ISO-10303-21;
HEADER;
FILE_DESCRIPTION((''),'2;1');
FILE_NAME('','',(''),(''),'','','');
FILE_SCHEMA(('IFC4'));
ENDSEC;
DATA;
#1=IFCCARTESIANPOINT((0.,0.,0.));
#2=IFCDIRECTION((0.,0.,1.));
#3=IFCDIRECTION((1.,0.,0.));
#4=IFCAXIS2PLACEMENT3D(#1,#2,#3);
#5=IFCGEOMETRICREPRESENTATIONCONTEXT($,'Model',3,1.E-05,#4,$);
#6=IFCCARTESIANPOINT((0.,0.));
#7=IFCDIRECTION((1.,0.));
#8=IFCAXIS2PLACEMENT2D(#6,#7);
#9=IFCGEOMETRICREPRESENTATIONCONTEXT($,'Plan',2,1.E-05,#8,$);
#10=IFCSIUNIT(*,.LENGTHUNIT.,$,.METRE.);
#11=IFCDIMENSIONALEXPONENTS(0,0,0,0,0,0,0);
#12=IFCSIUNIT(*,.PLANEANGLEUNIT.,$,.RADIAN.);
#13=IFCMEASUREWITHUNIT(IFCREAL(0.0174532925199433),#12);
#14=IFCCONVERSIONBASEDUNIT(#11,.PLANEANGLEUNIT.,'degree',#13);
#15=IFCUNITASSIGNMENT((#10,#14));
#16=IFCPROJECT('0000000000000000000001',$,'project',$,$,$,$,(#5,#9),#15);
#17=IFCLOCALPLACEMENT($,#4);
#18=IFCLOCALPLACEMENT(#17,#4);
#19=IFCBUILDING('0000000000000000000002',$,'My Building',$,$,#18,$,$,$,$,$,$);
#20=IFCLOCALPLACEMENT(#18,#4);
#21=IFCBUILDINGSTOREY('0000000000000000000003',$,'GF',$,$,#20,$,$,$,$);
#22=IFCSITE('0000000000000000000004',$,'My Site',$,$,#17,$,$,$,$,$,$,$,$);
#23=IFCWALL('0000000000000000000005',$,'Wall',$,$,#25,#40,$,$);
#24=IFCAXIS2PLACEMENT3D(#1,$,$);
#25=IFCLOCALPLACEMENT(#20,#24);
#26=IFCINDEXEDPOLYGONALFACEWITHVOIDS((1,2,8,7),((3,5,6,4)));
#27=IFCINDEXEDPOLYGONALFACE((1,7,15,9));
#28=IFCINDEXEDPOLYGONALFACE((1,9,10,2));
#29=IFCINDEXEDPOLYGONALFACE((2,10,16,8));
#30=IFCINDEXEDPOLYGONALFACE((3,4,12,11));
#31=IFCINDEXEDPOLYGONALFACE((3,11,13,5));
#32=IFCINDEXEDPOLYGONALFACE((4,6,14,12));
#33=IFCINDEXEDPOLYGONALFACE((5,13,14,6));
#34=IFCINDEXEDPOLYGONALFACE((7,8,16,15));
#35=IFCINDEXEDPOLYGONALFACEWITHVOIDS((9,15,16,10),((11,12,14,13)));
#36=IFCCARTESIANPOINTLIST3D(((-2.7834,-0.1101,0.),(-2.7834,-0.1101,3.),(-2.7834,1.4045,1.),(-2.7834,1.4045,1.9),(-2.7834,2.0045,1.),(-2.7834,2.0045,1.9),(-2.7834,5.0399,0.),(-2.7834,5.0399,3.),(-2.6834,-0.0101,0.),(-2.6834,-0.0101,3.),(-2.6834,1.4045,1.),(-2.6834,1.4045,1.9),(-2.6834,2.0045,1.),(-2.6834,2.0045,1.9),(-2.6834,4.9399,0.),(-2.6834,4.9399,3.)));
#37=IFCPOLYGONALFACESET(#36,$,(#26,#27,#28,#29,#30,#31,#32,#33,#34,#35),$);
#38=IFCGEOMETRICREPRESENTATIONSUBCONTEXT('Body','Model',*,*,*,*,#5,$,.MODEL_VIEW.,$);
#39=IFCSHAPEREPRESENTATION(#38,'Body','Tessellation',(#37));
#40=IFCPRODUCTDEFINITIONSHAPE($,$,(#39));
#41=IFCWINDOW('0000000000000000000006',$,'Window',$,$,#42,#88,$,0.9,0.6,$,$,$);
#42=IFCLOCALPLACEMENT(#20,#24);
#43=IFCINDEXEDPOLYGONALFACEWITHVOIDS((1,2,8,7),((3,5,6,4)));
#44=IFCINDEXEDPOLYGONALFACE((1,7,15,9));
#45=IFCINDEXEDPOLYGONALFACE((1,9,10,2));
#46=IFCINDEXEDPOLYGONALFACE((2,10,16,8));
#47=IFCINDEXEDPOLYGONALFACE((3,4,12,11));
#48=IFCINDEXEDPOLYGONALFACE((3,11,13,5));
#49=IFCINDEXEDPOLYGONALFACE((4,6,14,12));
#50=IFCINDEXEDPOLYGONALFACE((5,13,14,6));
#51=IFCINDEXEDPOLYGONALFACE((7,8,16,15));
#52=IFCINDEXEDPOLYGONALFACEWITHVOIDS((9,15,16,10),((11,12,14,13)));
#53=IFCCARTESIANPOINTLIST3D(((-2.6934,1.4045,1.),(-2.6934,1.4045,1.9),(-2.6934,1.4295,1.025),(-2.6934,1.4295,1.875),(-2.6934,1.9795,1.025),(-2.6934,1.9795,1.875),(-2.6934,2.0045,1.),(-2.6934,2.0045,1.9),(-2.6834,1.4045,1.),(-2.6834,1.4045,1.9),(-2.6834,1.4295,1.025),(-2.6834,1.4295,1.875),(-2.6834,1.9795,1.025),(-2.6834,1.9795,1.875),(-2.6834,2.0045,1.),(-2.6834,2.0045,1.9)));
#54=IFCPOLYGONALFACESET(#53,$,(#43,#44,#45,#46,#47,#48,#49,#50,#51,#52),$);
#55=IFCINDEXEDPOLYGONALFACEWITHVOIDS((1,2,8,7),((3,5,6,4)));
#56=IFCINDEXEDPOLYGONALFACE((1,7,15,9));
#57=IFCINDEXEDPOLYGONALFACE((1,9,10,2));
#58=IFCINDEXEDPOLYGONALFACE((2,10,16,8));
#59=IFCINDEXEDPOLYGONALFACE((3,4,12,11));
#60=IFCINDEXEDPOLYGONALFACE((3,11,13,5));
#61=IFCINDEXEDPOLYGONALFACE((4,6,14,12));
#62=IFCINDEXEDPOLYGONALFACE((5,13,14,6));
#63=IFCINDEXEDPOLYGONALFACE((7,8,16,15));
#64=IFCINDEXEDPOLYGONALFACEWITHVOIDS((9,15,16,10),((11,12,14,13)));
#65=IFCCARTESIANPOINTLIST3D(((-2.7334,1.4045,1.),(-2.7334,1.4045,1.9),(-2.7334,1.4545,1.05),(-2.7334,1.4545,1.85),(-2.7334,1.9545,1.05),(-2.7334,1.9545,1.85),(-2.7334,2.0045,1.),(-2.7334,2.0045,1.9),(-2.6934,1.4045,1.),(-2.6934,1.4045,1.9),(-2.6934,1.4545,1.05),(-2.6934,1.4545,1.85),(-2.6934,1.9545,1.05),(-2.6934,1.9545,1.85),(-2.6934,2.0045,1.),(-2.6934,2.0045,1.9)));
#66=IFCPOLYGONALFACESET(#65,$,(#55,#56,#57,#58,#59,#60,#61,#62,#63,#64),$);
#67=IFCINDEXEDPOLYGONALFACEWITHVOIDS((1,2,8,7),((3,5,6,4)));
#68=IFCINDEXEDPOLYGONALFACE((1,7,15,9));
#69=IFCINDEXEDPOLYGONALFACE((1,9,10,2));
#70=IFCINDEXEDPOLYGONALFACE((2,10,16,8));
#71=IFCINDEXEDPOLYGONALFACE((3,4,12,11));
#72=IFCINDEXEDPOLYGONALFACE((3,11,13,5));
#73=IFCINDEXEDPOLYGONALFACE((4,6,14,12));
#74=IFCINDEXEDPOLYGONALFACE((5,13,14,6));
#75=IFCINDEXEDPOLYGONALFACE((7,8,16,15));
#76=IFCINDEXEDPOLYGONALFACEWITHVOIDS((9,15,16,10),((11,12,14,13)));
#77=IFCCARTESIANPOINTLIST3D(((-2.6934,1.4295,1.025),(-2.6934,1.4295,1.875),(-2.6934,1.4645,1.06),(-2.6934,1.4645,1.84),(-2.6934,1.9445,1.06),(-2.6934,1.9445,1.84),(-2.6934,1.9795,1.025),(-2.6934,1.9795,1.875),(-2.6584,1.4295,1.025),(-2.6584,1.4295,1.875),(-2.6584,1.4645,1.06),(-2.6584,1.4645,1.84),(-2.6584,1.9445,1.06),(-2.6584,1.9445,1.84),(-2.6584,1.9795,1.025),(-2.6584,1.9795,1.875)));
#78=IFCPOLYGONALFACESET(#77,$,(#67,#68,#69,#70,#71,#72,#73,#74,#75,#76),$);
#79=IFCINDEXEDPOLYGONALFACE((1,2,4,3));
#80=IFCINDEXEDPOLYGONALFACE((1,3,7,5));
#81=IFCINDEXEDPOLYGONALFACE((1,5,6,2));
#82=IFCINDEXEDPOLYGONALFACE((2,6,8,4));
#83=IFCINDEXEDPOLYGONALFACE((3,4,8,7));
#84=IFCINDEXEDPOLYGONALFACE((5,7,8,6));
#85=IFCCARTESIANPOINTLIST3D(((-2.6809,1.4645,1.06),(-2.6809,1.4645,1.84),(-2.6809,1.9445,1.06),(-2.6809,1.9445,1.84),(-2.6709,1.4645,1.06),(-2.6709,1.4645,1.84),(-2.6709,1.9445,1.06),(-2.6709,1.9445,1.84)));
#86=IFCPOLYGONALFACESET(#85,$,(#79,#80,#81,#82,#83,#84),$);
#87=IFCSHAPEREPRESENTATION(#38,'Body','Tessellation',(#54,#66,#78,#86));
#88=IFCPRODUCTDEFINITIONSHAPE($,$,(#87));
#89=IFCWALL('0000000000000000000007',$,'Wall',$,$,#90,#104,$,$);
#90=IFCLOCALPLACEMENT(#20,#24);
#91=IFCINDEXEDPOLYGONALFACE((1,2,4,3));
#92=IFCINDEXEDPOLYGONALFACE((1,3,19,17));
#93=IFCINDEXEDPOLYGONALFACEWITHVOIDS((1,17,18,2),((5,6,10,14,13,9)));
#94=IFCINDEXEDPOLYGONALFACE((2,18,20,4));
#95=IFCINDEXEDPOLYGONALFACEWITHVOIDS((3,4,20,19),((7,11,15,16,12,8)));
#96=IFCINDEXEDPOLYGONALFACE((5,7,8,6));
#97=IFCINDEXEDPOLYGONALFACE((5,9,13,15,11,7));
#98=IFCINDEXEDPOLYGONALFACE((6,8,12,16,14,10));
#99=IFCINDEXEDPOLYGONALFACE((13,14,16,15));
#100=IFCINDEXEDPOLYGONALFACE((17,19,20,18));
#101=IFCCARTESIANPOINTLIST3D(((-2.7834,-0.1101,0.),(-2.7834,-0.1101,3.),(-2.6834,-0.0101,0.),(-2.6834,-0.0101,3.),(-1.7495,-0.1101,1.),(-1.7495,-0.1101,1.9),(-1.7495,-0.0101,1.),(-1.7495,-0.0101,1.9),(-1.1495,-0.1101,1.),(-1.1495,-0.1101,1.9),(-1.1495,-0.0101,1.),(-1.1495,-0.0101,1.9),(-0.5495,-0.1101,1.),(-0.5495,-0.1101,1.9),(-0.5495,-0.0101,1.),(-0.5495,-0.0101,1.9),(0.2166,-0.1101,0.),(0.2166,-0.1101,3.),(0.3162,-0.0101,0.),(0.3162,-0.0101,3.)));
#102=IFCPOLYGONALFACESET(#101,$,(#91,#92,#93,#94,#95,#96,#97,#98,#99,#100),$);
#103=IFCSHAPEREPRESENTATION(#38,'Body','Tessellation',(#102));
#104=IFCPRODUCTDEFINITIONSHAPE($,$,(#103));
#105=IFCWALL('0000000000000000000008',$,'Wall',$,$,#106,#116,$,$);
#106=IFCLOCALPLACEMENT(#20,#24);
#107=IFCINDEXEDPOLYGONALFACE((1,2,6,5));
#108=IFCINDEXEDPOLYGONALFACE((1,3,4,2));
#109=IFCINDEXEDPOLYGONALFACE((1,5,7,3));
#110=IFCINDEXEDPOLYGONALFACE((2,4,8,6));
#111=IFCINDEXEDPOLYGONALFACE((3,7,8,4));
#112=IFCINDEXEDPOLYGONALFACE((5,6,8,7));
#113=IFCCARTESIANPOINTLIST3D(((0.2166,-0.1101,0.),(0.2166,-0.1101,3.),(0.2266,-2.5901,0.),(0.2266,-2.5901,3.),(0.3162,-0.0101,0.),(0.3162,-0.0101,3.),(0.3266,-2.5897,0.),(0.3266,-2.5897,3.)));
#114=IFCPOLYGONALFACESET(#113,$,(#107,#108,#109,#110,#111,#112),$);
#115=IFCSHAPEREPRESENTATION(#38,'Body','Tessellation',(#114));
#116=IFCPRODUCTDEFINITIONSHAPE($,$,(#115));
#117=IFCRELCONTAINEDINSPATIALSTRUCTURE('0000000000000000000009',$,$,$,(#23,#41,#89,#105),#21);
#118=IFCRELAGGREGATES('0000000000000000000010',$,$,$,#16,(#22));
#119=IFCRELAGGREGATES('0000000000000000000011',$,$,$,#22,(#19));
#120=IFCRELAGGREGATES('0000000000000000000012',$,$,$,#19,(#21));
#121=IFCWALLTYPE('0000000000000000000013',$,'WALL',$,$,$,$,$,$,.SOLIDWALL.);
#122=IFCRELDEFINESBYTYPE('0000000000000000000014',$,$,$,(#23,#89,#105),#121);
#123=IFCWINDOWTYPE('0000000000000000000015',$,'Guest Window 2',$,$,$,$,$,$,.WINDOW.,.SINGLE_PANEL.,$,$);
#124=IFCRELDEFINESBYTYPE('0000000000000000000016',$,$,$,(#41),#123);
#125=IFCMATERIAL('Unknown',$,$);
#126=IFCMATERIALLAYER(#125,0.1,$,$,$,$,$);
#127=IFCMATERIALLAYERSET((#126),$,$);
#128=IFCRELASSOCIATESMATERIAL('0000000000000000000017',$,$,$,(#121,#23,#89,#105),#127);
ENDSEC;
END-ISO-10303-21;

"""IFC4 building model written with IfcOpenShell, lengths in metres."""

from ifc_helpers import new_model, entity, si_unit, converted_unit, frame, origin_with_axes, origin_2d_with_axis, place, context, subcontext, project, spatial, line, indexed_curve, outline, extrude, shape, source, transform, mapped, material, layer, layer_set, layer_usage, type_object, type_shapes, element, fill, save


model = new_model("IFC4")

# Units and contexts
model_context = context("Model", 3, precision=1e-05, world=origin_with_axes())
plan_context = context("Plan", 2, precision=1e-05, world=origin_2d_with_axis())
body_context_1 = subcontext(model_context, "Body", "Model", "MODEL_VIEW")
body_context_2 = subcontext(plan_context, "Body", "Plan", "PLAN_VIEW")
ifc_project = project(units=[si_unit("LENGTHUNIT", "METRE"), converted_unit("PLANEANGLEUNIT", "degree", entity("IfcReal", 0.0174532925199433), si_unit("PLANEANGLEUNIT", "RADIAN"), dimensions=[0, 0, 0, 0, 0, 0, 0])], contexts=[model_context, plan_context])

# Site, building, storey
site_placement = place(None, origin_with_axes())
site = spatial("IfcSite", under=ifc_project, at=site_placement, Name="My Site")
building_placement = place(site_placement, origin_with_axes())
building = spatial("IfcBuilding", under=site, at=building_placement, Name="My Building")
storey_placement = place(building_placement, origin_with_axes())
storey = spatial("IfcBuildingStorey", under=building, at=storey_placement, Name="GF")

# Shared definitions
ifc_material_1 = material(Name="Unknown")

# Shared definitions
ifc_layer_1 = layer(ifc_material_1, 0.1)
ifc_layer_set_1 = layer_set([ifc_layer_1])
wall_type = type_object("IfcWallType", Name="WALL", PredefinedType="SOLIDWALL", material=ifc_layer_set_1)

# Wall, opening, window
ifc_layer_usage_1 = layer_usage(ifc_layer_set_1, "AXIS2", "POSITIVE", 0.0)
wall_1_placement = place(storey_placement, frame((-2.7834, 5.0399, 0.0), z_axis=(0.0, 0.0, 1.0), x_axis=(0.0, -1.0, 0.0)))
wall_1 = element("IfcWall", 1, at=wall_1_placement, inside=storey, type_object=wall_type, material=ifc_layer_usage_1, Name="Wall", context=body_context_1, shape_type="SweptSolid", body=[
    extrude(outline(indexed_curve([(0.0, 0.0), (0.1, 0.1), (5.05, 0.1), (5.15, 0.0)], segments=[line(1, 2, 3, 4, 1)])), origin_with_axes(), (0.0, 0.0, 1.0), 3.0),
])
shared_shape_1 = source(origin_with_axes(), body_context_1, "Body", "SweptSolid", [
    extrude(outline(indexed_curve([(0.0, 0.0), (0.6, 0.0), (0.6, 0.9), (0.0, 0.9)], segments=[line(1, 2, 3, 4, 1)])), frame((0.0, -0.6, 0.0), z_axis=(0.0, -1.0, 0.0), x_axis=(1.0, 0.0, 0.0)), (0.0, 0.0, -1.0), 1.2),
])
opening_1_placement = place(wall_1_placement, frame((3.0354, 0.0, 1.0), z_axis=(0.0, 0.0, 1.0), x_axis=(1.0, 0.0, 0.0)))
opening_1 = element("IfcOpeningElement", 2, at=opening_1_placement, cuts=wall_1, PredefinedType="OPENING", context=body_context_1, shape_type="MappedRepresentation", body=[
    mapped(shared_shape_1, transform((0.0, 0.0, 0.0), x_axis=(1.0, 0.0, 0.0), y_axis=(0.0, 1.0, 0.0), z_axis=(0.0, 0.0, 1.0), scale=1.0)),
])
window_type_1 = type_object("IfcWindowType", Name="Guest Window 2", PartitioningType="SINGLE_PANEL", PredefinedType="WINDOW")
shared_shape_2 = source(origin_with_axes(), body_context_1, "Body", "SweptSolid", [
    extrude(outline(indexed_curve([(0.0, 0.0), (0.6, 0.0), (0.6, 0.9), (0.0, 0.9)], segments=[line(1, 2, 3, 4, 1)]), holes=[indexed_curve([(0.025, 0.025), (0.575, 0.025), (0.575, 0.875), (0.025, 0.875)], segments=[line(1, 2, 3, 4, 1)])]), frame((0.0, 0.09, 0.0), z_axis=(0.0, -1.0, 0.0), x_axis=(1.0, 0.0, 0.0)), (0.0, 0.0, -1.0), 0.01),
    extrude(outline(indexed_curve([(0.0, 0.0), (0.6, 0.0), (0.6, 0.9), (0.0, 0.9)], segments=[line(1, 2, 3, 4, 1)]), holes=[indexed_curve([(0.05, 0.05), (0.55, 0.05), (0.55, 0.85), (0.05, 0.85)], segments=[line(1, 2, 3, 4, 1)])]), frame((0.0, 0.05, 0.0), z_axis=(0.0, -1.0, 0.0), x_axis=(1.0, 0.0, 0.0)), (0.0, 0.0, -1.0), 0.04),
    extrude(outline(indexed_curve([(0.0, 0.0), (0.55, 0.0), (0.55, 0.85), (0.0, 0.85)], segments=[line(1, 2, 3, 4, 1)]), holes=[indexed_curve([(0.035, 0.035), (0.515, 0.035), (0.515, 0.815), (0.035, 0.815)], segments=[line(1, 2, 3, 4, 1)])]), frame((0.025, 0.09, 0.025), z_axis=(0.0, -1.0, 0.0), x_axis=(1.0, 0.0, 0.0)), (0.0, 0.0, -1.0), 0.035),
    extrude(outline(indexed_curve([(0.035, 0.035), (0.515, 0.035), (0.515, 0.815), (0.035, 0.815)], segments=[line(1, 2, 3, 4, 1)])), frame((0.025, 0.1025, 0.025), z_axis=(0.0, -1.0, 0.0), x_axis=(1.0, 0.0, 0.0)), (0.0, 0.0, -1.0), 0.01),
])
shared_shape_3 = source(origin_with_axes(), body_context_2, "Body", "Curve2D", [
    entity("IfcIndexedPolyCurve", entity("IfcCartesianPointList2D", [[0.05, 0.05], [0.55, 0.05]])),
    entity("IfcIndexedPolyCurve", entity("IfcCartesianPointList2D", [[0.0, 0.1], [0.025, 0.1], [0.025, 0.09], [0.05, 0.09], [0.05, 0.05], [0.0, 0.05]]), [entity("IfcLineIndex", [1, 2, 3, 4, 5, 6, 1])]),
    entity("IfcIndexedPolyCurve", entity("IfcCartesianPointList2D", [[0.6, 0.1], [0.575, 0.1], [0.575, 0.09], [0.55, 0.09], [0.55, 0.05], [0.6, 0.05]]), [entity("IfcLineIndex", [1, 2, 3, 4, 5, 6, 1])]),
    entity("IfcIndexedPolyCurve", entity("IfcCartesianPointList2D", [[0.025, 0.09], [0.06, 0.09], [0.06, 0.125], [0.025, 0.125]]), [entity("IfcLineIndex", [1, 2, 3, 4, 1])]),
    entity("IfcIndexedPolyCurve", entity("IfcCartesianPointList2D", [[0.575, 0.09], [0.54, 0.09], [0.54, 0.125], [0.575, 0.125]]), [entity("IfcLineIndex", [1, 2, 3, 4, 1])]),
    entity("IfcIndexedPolyCurve", entity("IfcCartesianPointList2D", [[0.06, 0.09], [0.54, 0.09]])),
    entity("IfcIndexedPolyCurve", entity("IfcCartesianPointList2D", [[0.06, 0.125], [0.54, 0.125]])),
    entity("IfcIndexedPolyCurve", entity("IfcCartesianPointList2D", [[0.06, 0.1075], [0.54, 0.1075]])),
])
type_shapes(window_type_1, [shared_shape_2, shared_shape_3])
window_1_placement = place(opening_1_placement, frame((0.0, 0.0, 0.0), z_axis=(0.0, 0.0, 1.0), x_axis=(1.0, 0.0, 0.0)))
window_1 = element("IfcWindow", 3, at=window_1_placement, inside=storey, type_object=window_type_1, Name="Window", OverallHeight=0.9, OverallWidth=0.6, shapes=[
    shape(body_context_1, "Body", "MappedRepresentation", [mapped(shared_shape_2, transform((0.0, 0.0, 0.0), x_axis=(1.0, 0.0, 0.0), y_axis=(0.0, 1.0, 0.0), z_axis=(0.0, 0.0, 1.0), scale=1.0))]),
    shape(body_context_2, "Body", "MappedRepresentation", [mapped(shared_shape_3, transform((0.0, 0.0, 0.0), x_axis=(1.0, 0.0, 0.0), y_axis=(0.0, 1.0, 0.0), z_axis=(0.0, 0.0, 1.0), scale=1.0))]),
])
fill(opening_1, window_1)

# Wall, openings
ifc_layer_usage_2 = layer_usage(ifc_layer_set_1, "AXIS2", "POSITIVE", 0.0)
wall_2_placement = place(storey_placement, frame((-2.7834, -0.1101, 0.0), z_axis=(0.0, 0.0, 1.0), x_axis=(1.0, 0.0, 0.0)))
wall_2 = element("IfcWall", 4, at=wall_2_placement, inside=storey, type_object=wall_type, material=ifc_layer_usage_2, Name="Wall", context=body_context_1, shape_type="SweptSolid", body=[
    extrude(outline(indexed_curve([(0.0, 0.0), (0.1, 0.1), (3.0996, 0.1), (3.0, 0.0)], segments=[line(1, 2, 3, 4, 1)])), origin_with_axes(), (0.0, 0.0, 1.0), 3.0),
])
shared_shape_4 = source(origin_with_axes(), body_context_1, "Body", "SweptSolid", [
    extrude(outline(indexed_curve([(0.0, 0.0), (0.6, 0.0), (0.6, 0.9), (0.0, 0.9)], segments=[line(1, 2, 3, 4, 1)])), frame((0.0, -0.6, 0.0), z_axis=(0.0, -1.0, 0.0), x_axis=(1.0, 0.0, 0.0)), (0.0, 0.0, -1.0), 1.2),
])
opening_2_placement = place(wall_2_placement, frame((1.0339, 0.0, 1.0), z_axis=(0.0, 0.0, 1.0), x_axis=(1.0, 0.0, 0.0)))
element("IfcOpeningElement", 5, at=opening_2_placement, cuts=wall_2, PredefinedType="OPENING", context=body_context_1, shape_type="MappedRepresentation", body=[
    mapped(shared_shape_4, transform((0.0, 0.0, 0.0), x_axis=(1.0, 0.0, 0.0), y_axis=(0.0, 1.0, 0.0), z_axis=(0.0, 0.0, 1.0), scale=1.0)),
])
opening_3_placement = place(wall_2_placement, frame((1.6339, 0.0, 1.0), z_axis=(0.0, 0.0, 1.0), x_axis=(1.0, 0.0, 0.0)))
element("IfcOpeningElement", 6, at=opening_3_placement, cuts=wall_2, PredefinedType="OPENING", context=body_context_1, shape_type="MappedRepresentation", body=[
    mapped(shared_shape_4, transform((0.0, 0.0, 0.0), x_axis=(1.0, 0.0, 0.0), y_axis=(0.0, 1.0, 0.0), z_axis=(0.0, 0.0, 1.0), scale=1.0)),
])

# Wall
ifc_layer_usage_3 = layer_usage(ifc_layer_set_1, "AXIS2", "POSITIVE", 0.0)
wall_3_placement = place(storey_placement, frame((0.2166, -0.1101, 0.0), z_axis=(0.0, 0.0, 1.0), x_axis=(0.004032, -0.999992, 0.0)))
element("IfcWall", 7, at=wall_3_placement, inside=storey, type_object=wall_type, material=ifc_layer_usage_3, Name="Wall", context=body_context_1, shape_type="SweptSolid", body=[
    extrude(outline(indexed_curve([(0.0, 0.0), (-0.0996, 0.1), (2.48, 0.1), (2.48, 0.0)], segments=[line(1, 2, 3, 4, 1)])), origin_with_axes(), (0.0, 0.0, 1.0), 3.0),
])

save(model, "model.ifc")
